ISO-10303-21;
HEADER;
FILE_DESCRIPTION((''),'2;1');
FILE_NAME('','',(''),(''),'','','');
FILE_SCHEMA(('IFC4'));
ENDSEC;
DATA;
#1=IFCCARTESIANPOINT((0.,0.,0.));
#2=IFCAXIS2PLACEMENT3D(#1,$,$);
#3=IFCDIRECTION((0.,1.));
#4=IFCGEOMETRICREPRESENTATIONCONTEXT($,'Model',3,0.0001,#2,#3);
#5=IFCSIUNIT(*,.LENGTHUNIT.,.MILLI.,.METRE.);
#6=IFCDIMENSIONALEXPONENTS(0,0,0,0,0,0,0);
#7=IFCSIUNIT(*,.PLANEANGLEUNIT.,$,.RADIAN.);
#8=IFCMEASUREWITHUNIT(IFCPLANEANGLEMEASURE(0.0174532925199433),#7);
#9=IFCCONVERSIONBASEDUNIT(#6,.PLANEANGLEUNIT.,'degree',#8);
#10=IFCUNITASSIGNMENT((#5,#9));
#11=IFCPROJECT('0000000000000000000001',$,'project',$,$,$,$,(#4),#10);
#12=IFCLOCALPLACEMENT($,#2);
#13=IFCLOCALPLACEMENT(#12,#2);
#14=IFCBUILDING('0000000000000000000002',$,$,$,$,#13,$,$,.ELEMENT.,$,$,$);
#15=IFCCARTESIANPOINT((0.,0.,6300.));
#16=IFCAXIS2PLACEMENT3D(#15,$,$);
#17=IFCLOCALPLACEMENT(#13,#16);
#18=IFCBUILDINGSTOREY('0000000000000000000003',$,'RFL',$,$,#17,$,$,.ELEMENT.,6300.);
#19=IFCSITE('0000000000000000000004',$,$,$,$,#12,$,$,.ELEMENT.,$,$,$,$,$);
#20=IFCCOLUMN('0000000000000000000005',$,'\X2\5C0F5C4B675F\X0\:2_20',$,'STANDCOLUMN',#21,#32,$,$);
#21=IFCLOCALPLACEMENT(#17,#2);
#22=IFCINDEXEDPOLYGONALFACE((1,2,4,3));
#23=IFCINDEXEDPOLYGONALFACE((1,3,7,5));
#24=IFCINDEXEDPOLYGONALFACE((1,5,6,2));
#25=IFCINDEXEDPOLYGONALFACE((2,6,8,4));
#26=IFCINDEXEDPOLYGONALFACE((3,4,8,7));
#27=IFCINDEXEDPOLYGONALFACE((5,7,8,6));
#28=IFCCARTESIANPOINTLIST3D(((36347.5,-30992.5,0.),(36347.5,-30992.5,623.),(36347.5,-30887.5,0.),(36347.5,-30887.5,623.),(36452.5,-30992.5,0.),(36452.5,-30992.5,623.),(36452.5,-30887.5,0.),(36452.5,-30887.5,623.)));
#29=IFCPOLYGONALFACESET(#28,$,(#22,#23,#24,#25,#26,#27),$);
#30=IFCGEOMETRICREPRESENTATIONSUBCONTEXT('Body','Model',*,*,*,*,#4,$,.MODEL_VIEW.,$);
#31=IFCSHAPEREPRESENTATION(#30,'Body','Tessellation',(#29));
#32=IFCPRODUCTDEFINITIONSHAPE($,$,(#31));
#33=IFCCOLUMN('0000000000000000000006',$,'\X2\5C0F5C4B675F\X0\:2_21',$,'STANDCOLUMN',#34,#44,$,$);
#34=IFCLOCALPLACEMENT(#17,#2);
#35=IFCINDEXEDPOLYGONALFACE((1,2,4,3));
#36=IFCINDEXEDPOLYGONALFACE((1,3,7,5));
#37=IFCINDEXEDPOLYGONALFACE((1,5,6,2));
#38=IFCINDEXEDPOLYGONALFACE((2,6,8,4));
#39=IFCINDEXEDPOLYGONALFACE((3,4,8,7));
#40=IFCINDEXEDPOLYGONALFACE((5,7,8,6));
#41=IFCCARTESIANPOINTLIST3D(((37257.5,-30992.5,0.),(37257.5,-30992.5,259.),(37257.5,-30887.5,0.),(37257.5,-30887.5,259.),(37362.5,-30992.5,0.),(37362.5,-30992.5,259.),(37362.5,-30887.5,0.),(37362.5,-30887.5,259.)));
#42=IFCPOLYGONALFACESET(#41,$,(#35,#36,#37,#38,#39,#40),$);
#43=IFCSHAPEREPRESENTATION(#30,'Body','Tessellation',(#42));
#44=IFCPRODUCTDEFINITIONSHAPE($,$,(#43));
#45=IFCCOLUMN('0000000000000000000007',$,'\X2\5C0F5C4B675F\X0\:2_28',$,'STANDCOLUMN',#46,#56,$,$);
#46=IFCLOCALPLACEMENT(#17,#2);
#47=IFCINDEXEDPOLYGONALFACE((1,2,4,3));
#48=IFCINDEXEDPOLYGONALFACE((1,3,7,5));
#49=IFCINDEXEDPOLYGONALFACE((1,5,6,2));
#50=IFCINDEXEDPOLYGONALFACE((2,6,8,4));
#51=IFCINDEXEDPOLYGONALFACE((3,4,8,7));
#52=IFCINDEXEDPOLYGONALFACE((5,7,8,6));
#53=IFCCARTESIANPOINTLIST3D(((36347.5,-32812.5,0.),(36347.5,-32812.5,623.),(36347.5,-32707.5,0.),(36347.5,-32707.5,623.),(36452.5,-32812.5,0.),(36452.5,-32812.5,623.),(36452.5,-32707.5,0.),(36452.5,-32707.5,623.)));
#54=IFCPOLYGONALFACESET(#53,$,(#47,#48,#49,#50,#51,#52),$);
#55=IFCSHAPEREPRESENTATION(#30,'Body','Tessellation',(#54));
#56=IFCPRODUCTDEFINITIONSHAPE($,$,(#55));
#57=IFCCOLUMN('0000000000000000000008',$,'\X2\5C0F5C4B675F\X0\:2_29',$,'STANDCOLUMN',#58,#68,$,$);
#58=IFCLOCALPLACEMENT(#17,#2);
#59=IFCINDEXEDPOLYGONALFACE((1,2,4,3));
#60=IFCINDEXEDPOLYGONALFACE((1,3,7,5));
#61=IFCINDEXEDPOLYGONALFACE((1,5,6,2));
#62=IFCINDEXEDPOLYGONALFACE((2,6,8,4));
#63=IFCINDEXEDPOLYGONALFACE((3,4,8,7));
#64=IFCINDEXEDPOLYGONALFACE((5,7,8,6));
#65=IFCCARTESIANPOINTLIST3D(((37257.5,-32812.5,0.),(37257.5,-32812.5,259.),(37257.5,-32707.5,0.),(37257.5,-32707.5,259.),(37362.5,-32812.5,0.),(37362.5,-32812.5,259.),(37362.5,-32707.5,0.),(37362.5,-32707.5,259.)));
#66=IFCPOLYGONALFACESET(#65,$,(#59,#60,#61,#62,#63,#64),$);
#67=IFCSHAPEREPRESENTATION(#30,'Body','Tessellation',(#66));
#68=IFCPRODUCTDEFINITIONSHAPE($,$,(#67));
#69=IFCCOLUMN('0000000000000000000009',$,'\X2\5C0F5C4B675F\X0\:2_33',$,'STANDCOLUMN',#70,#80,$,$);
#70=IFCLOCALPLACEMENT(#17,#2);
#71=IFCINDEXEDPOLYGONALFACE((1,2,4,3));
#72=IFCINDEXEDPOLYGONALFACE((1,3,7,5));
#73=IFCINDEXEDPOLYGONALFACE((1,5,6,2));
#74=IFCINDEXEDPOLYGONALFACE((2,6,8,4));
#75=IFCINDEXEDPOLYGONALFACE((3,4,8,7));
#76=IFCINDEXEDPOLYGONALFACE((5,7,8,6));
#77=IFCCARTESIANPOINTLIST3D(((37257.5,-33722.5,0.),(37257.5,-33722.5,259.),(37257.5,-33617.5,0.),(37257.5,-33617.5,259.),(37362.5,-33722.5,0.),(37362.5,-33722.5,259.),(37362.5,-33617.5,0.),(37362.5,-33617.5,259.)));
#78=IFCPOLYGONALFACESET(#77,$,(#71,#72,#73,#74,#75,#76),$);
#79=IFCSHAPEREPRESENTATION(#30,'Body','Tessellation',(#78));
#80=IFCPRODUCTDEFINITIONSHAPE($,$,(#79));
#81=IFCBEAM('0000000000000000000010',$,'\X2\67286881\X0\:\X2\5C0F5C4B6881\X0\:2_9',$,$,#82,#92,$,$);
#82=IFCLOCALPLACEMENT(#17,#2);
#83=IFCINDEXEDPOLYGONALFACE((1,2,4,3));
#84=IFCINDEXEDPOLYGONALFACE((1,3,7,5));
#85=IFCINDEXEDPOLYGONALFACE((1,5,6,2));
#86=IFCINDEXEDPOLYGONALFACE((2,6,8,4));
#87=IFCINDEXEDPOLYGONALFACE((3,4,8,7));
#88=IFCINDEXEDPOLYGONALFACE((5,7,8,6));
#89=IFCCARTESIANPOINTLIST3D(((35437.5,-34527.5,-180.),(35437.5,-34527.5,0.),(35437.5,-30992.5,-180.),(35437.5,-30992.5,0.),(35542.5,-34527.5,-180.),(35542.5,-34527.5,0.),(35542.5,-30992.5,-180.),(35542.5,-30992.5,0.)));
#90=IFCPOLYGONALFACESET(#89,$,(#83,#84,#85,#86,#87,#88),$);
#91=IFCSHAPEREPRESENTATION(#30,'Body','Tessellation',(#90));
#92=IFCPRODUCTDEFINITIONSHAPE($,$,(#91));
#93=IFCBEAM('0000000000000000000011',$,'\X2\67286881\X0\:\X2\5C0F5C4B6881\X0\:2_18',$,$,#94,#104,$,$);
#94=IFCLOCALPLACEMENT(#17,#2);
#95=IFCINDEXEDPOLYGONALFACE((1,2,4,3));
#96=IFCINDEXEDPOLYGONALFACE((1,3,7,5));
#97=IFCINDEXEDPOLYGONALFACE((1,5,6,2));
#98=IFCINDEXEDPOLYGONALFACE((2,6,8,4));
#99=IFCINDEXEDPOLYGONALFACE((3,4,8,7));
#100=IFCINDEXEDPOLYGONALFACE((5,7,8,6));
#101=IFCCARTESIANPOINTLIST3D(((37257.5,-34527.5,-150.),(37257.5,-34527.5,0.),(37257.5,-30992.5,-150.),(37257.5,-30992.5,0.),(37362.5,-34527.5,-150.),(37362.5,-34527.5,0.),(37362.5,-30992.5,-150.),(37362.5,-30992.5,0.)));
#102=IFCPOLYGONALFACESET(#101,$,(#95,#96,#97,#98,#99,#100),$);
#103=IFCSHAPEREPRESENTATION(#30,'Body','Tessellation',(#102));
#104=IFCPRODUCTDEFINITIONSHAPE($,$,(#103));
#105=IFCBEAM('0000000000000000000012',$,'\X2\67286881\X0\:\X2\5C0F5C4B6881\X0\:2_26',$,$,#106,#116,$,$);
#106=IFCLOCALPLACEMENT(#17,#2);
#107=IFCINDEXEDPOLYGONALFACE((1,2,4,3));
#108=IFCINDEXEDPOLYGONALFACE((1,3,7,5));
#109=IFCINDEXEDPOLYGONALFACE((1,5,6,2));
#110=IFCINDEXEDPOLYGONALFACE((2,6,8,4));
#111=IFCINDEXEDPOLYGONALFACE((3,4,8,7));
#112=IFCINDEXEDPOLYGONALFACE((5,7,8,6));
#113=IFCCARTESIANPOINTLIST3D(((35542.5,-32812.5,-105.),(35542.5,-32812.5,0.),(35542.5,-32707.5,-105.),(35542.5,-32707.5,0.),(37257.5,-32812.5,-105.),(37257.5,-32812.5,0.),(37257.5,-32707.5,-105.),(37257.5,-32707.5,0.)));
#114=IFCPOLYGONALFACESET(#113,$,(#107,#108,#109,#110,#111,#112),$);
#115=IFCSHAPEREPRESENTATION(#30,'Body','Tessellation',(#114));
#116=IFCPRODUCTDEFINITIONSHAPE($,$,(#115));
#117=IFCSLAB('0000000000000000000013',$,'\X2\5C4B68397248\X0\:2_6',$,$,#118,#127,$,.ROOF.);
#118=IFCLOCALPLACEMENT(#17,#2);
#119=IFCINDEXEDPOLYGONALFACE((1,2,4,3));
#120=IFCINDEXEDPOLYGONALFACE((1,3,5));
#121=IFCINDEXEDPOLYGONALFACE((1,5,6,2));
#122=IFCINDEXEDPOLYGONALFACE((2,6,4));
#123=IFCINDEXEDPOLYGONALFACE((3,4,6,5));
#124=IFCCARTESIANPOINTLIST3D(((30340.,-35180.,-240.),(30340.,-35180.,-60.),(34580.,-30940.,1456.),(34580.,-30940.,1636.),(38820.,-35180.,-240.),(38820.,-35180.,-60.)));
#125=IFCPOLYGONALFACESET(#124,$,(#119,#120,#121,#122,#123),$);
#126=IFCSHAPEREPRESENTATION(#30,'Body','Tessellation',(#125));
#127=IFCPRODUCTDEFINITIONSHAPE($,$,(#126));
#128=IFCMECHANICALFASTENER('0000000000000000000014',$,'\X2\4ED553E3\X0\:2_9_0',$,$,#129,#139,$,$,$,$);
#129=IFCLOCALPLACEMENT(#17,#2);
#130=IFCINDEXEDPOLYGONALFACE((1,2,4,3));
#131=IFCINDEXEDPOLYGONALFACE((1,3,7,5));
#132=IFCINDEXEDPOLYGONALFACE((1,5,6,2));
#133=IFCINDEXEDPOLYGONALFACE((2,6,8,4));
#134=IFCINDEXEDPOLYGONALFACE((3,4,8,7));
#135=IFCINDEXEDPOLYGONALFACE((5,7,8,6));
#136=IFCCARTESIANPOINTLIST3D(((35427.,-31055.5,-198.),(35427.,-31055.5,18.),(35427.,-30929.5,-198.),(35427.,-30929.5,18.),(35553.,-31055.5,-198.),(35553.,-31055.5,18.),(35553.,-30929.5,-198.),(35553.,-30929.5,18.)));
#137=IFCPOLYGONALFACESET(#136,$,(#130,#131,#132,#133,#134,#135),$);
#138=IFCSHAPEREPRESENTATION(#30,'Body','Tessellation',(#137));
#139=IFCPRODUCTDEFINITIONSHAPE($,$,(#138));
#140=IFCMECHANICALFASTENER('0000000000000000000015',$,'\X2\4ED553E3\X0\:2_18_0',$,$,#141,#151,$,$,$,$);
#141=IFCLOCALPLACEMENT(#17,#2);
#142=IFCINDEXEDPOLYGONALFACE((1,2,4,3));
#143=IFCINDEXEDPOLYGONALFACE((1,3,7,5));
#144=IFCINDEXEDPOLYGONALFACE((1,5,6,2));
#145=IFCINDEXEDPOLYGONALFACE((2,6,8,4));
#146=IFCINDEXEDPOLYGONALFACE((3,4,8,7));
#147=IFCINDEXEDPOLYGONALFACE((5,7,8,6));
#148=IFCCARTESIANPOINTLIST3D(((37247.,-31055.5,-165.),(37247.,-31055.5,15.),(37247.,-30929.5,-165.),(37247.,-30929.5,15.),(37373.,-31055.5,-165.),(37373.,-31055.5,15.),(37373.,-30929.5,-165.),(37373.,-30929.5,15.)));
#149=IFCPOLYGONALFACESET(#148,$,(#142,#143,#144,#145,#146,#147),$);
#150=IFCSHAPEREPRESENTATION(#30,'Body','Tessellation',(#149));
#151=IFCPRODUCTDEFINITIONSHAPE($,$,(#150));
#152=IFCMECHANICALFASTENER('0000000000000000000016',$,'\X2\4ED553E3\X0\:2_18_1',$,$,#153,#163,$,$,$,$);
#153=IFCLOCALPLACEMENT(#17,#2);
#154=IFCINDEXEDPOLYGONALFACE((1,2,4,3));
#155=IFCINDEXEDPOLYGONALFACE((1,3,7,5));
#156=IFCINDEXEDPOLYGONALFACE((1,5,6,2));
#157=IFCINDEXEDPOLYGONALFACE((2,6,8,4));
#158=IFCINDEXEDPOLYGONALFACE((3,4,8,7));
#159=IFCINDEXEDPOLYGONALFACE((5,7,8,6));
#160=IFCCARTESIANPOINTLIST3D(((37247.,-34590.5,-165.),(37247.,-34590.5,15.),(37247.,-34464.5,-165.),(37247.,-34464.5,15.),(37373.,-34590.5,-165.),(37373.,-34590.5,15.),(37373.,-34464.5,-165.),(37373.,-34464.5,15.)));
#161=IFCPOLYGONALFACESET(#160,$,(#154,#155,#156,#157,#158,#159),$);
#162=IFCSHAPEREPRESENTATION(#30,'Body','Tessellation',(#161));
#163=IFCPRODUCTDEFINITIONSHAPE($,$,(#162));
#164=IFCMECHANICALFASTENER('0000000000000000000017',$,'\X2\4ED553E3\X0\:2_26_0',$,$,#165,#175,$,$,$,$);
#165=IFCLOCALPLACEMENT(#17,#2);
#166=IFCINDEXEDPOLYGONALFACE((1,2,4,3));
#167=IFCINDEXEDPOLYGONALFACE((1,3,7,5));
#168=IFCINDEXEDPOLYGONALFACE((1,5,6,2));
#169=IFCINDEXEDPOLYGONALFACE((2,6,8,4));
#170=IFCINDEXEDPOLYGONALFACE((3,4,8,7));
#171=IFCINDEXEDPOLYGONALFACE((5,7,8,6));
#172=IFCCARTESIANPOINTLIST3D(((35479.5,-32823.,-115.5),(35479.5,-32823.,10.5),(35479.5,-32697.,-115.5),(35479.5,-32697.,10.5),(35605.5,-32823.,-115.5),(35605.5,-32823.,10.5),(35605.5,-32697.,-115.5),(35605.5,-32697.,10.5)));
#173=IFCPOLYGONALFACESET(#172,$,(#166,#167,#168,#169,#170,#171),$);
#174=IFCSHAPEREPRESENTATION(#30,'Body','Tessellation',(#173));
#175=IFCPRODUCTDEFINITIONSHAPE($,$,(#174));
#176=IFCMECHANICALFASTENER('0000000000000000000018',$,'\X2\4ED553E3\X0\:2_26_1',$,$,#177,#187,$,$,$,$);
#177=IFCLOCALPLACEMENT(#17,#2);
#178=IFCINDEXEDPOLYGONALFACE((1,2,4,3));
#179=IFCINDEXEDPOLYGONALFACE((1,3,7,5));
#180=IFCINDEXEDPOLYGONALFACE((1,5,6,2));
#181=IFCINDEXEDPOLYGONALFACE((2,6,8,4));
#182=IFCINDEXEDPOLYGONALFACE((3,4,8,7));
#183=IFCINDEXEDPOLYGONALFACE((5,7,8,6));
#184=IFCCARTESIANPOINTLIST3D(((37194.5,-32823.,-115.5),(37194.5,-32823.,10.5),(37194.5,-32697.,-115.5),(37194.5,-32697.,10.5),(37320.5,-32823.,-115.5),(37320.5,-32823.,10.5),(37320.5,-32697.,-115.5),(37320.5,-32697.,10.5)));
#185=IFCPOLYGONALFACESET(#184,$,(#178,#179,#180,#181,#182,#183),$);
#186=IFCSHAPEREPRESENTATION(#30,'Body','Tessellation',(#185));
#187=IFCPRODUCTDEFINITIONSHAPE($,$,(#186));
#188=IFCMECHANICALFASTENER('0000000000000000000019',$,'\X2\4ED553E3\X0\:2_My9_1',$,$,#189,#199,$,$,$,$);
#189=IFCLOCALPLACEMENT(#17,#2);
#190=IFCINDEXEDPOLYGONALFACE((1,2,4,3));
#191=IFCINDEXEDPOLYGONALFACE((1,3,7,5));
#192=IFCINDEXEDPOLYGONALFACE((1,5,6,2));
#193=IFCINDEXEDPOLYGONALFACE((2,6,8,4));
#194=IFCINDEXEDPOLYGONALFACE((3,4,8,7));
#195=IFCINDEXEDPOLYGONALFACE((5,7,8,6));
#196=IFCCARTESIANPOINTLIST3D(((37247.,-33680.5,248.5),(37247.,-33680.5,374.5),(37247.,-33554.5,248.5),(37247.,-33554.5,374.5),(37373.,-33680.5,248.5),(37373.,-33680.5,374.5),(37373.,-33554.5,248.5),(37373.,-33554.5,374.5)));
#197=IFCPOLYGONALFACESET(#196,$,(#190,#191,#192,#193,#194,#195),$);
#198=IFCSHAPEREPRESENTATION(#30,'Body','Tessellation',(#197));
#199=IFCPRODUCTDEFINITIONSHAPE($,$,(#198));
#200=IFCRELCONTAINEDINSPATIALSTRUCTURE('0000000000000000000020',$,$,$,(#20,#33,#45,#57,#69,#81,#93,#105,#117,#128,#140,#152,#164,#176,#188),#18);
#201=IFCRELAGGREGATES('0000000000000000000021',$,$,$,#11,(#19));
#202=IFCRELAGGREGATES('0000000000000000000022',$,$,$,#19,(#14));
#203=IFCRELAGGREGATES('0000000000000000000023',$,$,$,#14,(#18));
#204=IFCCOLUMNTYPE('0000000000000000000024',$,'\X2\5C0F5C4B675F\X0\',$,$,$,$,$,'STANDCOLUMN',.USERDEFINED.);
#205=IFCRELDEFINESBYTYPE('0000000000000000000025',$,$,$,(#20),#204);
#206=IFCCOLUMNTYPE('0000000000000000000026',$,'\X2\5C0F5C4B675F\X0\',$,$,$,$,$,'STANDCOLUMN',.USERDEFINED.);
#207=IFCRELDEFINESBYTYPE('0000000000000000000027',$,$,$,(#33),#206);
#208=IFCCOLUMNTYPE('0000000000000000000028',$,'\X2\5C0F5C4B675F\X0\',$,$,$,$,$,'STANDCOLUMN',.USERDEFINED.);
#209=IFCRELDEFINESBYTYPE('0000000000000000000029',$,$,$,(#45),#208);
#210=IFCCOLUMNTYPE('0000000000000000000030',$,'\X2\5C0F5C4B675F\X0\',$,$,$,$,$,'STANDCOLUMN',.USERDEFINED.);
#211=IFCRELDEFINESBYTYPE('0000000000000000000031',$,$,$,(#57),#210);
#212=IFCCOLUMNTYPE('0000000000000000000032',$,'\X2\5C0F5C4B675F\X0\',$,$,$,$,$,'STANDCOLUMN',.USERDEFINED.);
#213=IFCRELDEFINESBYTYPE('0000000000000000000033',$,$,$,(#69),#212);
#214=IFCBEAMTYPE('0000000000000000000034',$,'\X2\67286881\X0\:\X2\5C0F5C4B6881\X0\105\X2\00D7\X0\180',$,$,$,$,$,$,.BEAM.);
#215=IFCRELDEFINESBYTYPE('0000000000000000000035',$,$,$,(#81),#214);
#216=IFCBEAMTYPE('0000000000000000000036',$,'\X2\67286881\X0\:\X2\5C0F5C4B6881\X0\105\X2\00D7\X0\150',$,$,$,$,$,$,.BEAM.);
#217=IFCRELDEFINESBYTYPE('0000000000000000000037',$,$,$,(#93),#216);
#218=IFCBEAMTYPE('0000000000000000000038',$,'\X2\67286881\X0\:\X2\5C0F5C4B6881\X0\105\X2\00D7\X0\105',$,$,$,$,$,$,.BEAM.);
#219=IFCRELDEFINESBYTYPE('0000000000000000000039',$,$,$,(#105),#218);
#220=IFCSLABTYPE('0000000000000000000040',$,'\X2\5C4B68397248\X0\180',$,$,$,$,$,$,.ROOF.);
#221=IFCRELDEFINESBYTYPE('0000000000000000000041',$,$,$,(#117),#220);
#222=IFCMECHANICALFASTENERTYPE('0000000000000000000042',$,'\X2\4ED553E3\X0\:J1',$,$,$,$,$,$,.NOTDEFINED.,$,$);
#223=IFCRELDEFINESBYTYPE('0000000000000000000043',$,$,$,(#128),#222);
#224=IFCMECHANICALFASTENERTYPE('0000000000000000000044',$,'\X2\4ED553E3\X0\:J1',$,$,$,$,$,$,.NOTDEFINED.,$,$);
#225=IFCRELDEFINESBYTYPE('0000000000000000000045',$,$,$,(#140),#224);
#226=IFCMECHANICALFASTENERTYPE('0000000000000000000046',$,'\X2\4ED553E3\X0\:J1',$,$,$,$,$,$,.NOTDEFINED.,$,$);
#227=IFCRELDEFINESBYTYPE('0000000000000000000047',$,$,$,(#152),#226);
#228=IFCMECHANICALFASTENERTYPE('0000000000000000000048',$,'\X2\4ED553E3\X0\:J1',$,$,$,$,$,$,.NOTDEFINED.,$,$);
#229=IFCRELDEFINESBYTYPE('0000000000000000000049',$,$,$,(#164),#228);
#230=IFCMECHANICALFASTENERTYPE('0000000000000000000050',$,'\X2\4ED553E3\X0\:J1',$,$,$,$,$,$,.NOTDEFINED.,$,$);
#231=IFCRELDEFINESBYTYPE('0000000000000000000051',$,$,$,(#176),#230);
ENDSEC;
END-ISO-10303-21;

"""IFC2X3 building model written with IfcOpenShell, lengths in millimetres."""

from ifc_helpers import new_model, entity, si_unit, converted_unit, direction, frame, origin, origin_with_axes, origin_2d, place, context, subcontext, project, spatial, polyline, rectangle, outline, extrude, type_object, element, save


model = new_model("IFC2X3")

# Units and contexts
model_context = context("Model", 3, precision=0.0001, world=origin(), true_north=direction((0.0, 1.0)))
body_context = subcontext(model_context, "Body", "Model", "MODEL_VIEW")
ifc_project = project(units=[si_unit("LENGTHUNIT", "METRE", prefix="MILLI"), converted_unit("PLANEANGLEUNIT", "degree", entity("IfcPlaneAngleMeasure", 0.0174532925199433), si_unit("PLANEANGLEUNIT", "RADIAN"), dimensions=[0, 0, 0, 0, 0, 0, 0])], contexts=[model_context])

# Site, building, storey
site_placement = place(None, origin())
site = spatial("IfcSite", under=ifc_project, at=site_placement, CompositionType="ELEMENT")
building_placement = place(site_placement, origin())
building = spatial("IfcBuilding", under=site, at=building_placement, CompositionType="ELEMENT")
storey_placement = place(building_placement, frame((0.0, 0.0, 6300.0)))
storey = spatial("IfcBuildingStorey", under=building, at=storey_placement, Name="RFL", CompositionType="ELEMENT", Elevation=6300.0)

# Columns
column_type_1 = type_object("IfcColumnType", Name="小屋束", ElementType="STANDCOLUMN", PredefinedType="USERDEFINED")
column_1_placement = place(storey_placement, frame((36400.0, -30940.0, 0.0)))
element("IfcColumn", 1, at=column_1_placement, inside=storey, type_object=column_type_1, Name="小屋束:2_20", ObjectType="STANDCOLUMN", context=body_context, shape_type="SweptSolid", body=[
    extrude(rectangle(XDim=105.0, YDim=105.0, at=origin_2d()), origin_with_axes(), (0.0, 0.0, 1.0), 623.0),
])
column_type_2 = type_object("IfcColumnType", Name="小屋束", ElementType="STANDCOLUMN", PredefinedType="USERDEFINED")
column_2_placement = place(storey_placement, frame((37310.0, -30940.0, 0.0)))
element("IfcColumn", 2, at=column_2_placement, inside=storey, type_object=column_type_2, Name="小屋束:2_21", ObjectType="STANDCOLUMN", context=body_context, shape_type="SweptSolid", body=[
    extrude(rectangle(XDim=105.0, YDim=105.0, at=origin_2d()), origin_with_axes(), (0.0, 0.0, 1.0), 259.0),
])
column_type_3 = type_object("IfcColumnType", Name="小屋束", ElementType="STANDCOLUMN", PredefinedType="USERDEFINED")
column_3_placement = place(storey_placement, frame((36400.0, -32760.0, 0.0)))
element("IfcColumn", 3, at=column_3_placement, inside=storey, type_object=column_type_3, Name="小屋束:2_28", ObjectType="STANDCOLUMN", context=body_context, shape_type="SweptSolid", body=[
    extrude(rectangle(XDim=105.0, YDim=105.0, at=origin_2d()), origin_with_axes(), (0.0, 0.0, 1.0), 623.0),
])
column_type_4 = type_object("IfcColumnType", Name="小屋束", ElementType="STANDCOLUMN", PredefinedType="USERDEFINED")
column_4_placement = place(storey_placement, frame((37310.0, -32760.0, 0.0)))
element("IfcColumn", 4, at=column_4_placement, inside=storey, type_object=column_type_4, Name="小屋束:2_29", ObjectType="STANDCOLUMN", context=body_context, shape_type="SweptSolid", body=[
    extrude(rectangle(XDim=105.0, YDim=105.0, at=origin_2d()), origin_with_axes(), (0.0, 0.0, 1.0), 259.0),
])
column_type_5 = type_object("IfcColumnType", Name="小屋束", ElementType="STANDCOLUMN", PredefinedType="USERDEFINED")
column_5_placement = place(storey_placement, frame((37310.0, -33670.0, 0.0)))
element("IfcColumn", 5, at=column_5_placement, inside=storey, type_object=column_type_5, Name="小屋束:2_33", ObjectType="STANDCOLUMN", context=body_context, shape_type="SweptSolid", body=[
    extrude(rectangle(XDim=105.0, YDim=105.0, at=origin_2d()), origin_with_axes(), (0.0, 0.0, 1.0), 259.0),
])

# Beams
beam_type_1 = type_object("IfcBeamType", Name="木梁:小屋梁105×180", PredefinedType="BEAM")
beam_1_placement = place(storey_placement, frame((35490.0, -30992.5, -90.0), z_axis=(0.0, -1.0, 0.0), x_axis=(1.0, 0.0, 0.0)))
element("IfcBeam", 6, at=beam_1_placement, inside=storey, type_object=beam_type_1, Name="木梁:小屋梁:2_9", context=body_context, shape_type="SweptSolid", body=[
    extrude(rectangle(XDim=105.0, YDim=180.0, at=origin_2d()), origin_with_axes(), (0.0, 0.0, 1.0), 3535.0),
])
beam_type_2 = type_object("IfcBeamType", Name="木梁:小屋梁105×150", PredefinedType="BEAM")
beam_2_placement = place(storey_placement, frame((37310.0, -30992.5, -75.0), z_axis=(0.0, -1.0, 0.0), x_axis=(1.0, 0.0, 0.0)))
element("IfcBeam", 7, at=beam_2_placement, inside=storey, type_object=beam_type_2, Name="木梁:小屋梁:2_18", context=body_context, shape_type="SweptSolid", body=[
    extrude(rectangle(XDim=105.0, YDim=150.0, at=origin_2d()), origin_with_axes(), (0.0, 0.0, 1.0), 3535.0),
])
beam_type_3 = type_object("IfcBeamType", Name="木梁:小屋梁105×105", PredefinedType="BEAM")
beam_3_placement = place(storey_placement, frame((35542.5, -32760.0, -52.5), z_axis=(1.0, 0.0, 0.0), x_axis=(0.0, 1.0, 0.0)))
element("IfcBeam", 8, at=beam_3_placement, inside=storey, type_object=beam_type_3, Name="木梁:小屋梁:2_26", context=body_context, shape_type="SweptSolid", body=[
    extrude(rectangle(XDim=105.0, YDim=105.0, at=origin_2d()), origin_with_axes(), (0.0, 0.0, 1.0), 1715.0),
])

# Slab
slab_type = type_object("IfcSlabType", Name="屋根版180", PredefinedType="ROOF")
slab_placement = place(storey_placement, frame((38820.0, -35180.0, -240.0), z_axis=(0.0, 0.371391, -0.928477), x_axis=(-1.0, 0.0, 0.0)))
element("IfcSlab", 9, at=slab_placement, inside=storey, type_object=slab_type, Name="屋根版:2_6", PredefinedType="ROOF", context=body_context, shape_type="SweptSolid", body=[
    extrude(outline(polyline([(0.0, 0.0, 0.0), (8480.0, 0.0, 0.0), (4240.0, 4566.6, 0.0), (0.0, 0.0, 0.0)])), origin_with_axes(), (0.0, 0.371391, -0.928477), 180.0),
])

# Mechanical fasteners
mechanical_fastener_type_1 = type_object("IfcMechanicalFastenerType", Name="仕口:J1")
mechanical_fastener_1_placement = place(storey_placement, frame((35490.0, -30992.5, -198.0)))
element("IfcMechanicalFastener", 10, at=mechanical_fastener_1_placement, inside=storey, type_object=mechanical_fastener_type_1, Name="仕口:2_9_0", context=body_context, shape_type="SweptSolid", body=[
    extrude(rectangle(XDim=126.0, YDim=126.0, at=origin_2d()), origin_with_axes(), (0.0, 0.0, 1.0), 216.0),
])
mechanical_fastener_type_2 = type_object("IfcMechanicalFastenerType", Name="仕口:J1")
mechanical_fastener_2_placement = place(storey_placement, frame((37310.0, -30992.5, -165.0)))
element("IfcMechanicalFastener", 11, at=mechanical_fastener_2_placement, inside=storey, type_object=mechanical_fastener_type_2, Name="仕口:2_18_0", context=body_context, shape_type="SweptSolid", body=[
    extrude(rectangle(XDim=126.0, YDim=126.0, at=origin_2d()), origin_with_axes(), (0.0, 0.0, 1.0), 180.0),
])
mechanical_fastener_type_3 = type_object("IfcMechanicalFastenerType", Name="仕口:J1")
mechanical_fastener_3_placement = place(storey_placement, frame((37310.0, -34527.5, -165.0)))
element("IfcMechanicalFastener", 12, at=mechanical_fastener_3_placement, inside=storey, type_object=mechanical_fastener_type_3, Name="仕口:2_18_1", context=body_context, shape_type="SweptSolid", body=[
    extrude(rectangle(XDim=126.0, YDim=126.0, at=origin_2d()), origin_with_axes(), (0.0, 0.0, 1.0), 180.0),
])
mechanical_fastener_type_4 = type_object("IfcMechanicalFastenerType", Name="仕口:J1")
mechanical_fastener_4_placement = place(storey_placement, frame((35542.5, -32760.0, -115.5)))
element("IfcMechanicalFastener", 13, at=mechanical_fastener_4_placement, inside=storey, type_object=mechanical_fastener_type_4, Name="仕口:2_26_0", context=body_context, shape_type="SweptSolid", body=[
    extrude(rectangle(XDim=126.0, YDim=126.0, at=origin_2d()), origin_with_axes(), (0.0, 0.0, 1.0), 126.0),
])
mechanical_fastener_type_5 = type_object("IfcMechanicalFastenerType", Name="仕口:J1")
mechanical_fastener_5_placement = place(storey_placement, frame((37257.5, -32760.0, -115.5)))
element("IfcMechanicalFastener", 14, at=mechanical_fastener_5_placement, inside=storey, type_object=mechanical_fastener_type_5, Name="仕口:2_26_1", context=body_context, shape_type="SweptSolid", body=[
    extrude(rectangle(XDim=126.0, YDim=126.0, at=origin_2d()), origin_with_axes(), (0.0, 0.0, 1.0), 126.0),
])
for number, where, name in (
    (15, (37310.0, -33617.5, 248.5), "仕口:2_My9_1"),
):
    element("IfcMechanicalFastener", number, at=place(storey_placement, frame(where)), inside=storey, Name=name, context=body_context, shape_type="SweptSolid", body=[
        extrude(rectangle(XDim=126.0, YDim=126.0, at=origin_2d()), origin_with_axes(), (0.0, 0.0, 1.0), 126.0),
    ])

save(model, "model.ifc")
